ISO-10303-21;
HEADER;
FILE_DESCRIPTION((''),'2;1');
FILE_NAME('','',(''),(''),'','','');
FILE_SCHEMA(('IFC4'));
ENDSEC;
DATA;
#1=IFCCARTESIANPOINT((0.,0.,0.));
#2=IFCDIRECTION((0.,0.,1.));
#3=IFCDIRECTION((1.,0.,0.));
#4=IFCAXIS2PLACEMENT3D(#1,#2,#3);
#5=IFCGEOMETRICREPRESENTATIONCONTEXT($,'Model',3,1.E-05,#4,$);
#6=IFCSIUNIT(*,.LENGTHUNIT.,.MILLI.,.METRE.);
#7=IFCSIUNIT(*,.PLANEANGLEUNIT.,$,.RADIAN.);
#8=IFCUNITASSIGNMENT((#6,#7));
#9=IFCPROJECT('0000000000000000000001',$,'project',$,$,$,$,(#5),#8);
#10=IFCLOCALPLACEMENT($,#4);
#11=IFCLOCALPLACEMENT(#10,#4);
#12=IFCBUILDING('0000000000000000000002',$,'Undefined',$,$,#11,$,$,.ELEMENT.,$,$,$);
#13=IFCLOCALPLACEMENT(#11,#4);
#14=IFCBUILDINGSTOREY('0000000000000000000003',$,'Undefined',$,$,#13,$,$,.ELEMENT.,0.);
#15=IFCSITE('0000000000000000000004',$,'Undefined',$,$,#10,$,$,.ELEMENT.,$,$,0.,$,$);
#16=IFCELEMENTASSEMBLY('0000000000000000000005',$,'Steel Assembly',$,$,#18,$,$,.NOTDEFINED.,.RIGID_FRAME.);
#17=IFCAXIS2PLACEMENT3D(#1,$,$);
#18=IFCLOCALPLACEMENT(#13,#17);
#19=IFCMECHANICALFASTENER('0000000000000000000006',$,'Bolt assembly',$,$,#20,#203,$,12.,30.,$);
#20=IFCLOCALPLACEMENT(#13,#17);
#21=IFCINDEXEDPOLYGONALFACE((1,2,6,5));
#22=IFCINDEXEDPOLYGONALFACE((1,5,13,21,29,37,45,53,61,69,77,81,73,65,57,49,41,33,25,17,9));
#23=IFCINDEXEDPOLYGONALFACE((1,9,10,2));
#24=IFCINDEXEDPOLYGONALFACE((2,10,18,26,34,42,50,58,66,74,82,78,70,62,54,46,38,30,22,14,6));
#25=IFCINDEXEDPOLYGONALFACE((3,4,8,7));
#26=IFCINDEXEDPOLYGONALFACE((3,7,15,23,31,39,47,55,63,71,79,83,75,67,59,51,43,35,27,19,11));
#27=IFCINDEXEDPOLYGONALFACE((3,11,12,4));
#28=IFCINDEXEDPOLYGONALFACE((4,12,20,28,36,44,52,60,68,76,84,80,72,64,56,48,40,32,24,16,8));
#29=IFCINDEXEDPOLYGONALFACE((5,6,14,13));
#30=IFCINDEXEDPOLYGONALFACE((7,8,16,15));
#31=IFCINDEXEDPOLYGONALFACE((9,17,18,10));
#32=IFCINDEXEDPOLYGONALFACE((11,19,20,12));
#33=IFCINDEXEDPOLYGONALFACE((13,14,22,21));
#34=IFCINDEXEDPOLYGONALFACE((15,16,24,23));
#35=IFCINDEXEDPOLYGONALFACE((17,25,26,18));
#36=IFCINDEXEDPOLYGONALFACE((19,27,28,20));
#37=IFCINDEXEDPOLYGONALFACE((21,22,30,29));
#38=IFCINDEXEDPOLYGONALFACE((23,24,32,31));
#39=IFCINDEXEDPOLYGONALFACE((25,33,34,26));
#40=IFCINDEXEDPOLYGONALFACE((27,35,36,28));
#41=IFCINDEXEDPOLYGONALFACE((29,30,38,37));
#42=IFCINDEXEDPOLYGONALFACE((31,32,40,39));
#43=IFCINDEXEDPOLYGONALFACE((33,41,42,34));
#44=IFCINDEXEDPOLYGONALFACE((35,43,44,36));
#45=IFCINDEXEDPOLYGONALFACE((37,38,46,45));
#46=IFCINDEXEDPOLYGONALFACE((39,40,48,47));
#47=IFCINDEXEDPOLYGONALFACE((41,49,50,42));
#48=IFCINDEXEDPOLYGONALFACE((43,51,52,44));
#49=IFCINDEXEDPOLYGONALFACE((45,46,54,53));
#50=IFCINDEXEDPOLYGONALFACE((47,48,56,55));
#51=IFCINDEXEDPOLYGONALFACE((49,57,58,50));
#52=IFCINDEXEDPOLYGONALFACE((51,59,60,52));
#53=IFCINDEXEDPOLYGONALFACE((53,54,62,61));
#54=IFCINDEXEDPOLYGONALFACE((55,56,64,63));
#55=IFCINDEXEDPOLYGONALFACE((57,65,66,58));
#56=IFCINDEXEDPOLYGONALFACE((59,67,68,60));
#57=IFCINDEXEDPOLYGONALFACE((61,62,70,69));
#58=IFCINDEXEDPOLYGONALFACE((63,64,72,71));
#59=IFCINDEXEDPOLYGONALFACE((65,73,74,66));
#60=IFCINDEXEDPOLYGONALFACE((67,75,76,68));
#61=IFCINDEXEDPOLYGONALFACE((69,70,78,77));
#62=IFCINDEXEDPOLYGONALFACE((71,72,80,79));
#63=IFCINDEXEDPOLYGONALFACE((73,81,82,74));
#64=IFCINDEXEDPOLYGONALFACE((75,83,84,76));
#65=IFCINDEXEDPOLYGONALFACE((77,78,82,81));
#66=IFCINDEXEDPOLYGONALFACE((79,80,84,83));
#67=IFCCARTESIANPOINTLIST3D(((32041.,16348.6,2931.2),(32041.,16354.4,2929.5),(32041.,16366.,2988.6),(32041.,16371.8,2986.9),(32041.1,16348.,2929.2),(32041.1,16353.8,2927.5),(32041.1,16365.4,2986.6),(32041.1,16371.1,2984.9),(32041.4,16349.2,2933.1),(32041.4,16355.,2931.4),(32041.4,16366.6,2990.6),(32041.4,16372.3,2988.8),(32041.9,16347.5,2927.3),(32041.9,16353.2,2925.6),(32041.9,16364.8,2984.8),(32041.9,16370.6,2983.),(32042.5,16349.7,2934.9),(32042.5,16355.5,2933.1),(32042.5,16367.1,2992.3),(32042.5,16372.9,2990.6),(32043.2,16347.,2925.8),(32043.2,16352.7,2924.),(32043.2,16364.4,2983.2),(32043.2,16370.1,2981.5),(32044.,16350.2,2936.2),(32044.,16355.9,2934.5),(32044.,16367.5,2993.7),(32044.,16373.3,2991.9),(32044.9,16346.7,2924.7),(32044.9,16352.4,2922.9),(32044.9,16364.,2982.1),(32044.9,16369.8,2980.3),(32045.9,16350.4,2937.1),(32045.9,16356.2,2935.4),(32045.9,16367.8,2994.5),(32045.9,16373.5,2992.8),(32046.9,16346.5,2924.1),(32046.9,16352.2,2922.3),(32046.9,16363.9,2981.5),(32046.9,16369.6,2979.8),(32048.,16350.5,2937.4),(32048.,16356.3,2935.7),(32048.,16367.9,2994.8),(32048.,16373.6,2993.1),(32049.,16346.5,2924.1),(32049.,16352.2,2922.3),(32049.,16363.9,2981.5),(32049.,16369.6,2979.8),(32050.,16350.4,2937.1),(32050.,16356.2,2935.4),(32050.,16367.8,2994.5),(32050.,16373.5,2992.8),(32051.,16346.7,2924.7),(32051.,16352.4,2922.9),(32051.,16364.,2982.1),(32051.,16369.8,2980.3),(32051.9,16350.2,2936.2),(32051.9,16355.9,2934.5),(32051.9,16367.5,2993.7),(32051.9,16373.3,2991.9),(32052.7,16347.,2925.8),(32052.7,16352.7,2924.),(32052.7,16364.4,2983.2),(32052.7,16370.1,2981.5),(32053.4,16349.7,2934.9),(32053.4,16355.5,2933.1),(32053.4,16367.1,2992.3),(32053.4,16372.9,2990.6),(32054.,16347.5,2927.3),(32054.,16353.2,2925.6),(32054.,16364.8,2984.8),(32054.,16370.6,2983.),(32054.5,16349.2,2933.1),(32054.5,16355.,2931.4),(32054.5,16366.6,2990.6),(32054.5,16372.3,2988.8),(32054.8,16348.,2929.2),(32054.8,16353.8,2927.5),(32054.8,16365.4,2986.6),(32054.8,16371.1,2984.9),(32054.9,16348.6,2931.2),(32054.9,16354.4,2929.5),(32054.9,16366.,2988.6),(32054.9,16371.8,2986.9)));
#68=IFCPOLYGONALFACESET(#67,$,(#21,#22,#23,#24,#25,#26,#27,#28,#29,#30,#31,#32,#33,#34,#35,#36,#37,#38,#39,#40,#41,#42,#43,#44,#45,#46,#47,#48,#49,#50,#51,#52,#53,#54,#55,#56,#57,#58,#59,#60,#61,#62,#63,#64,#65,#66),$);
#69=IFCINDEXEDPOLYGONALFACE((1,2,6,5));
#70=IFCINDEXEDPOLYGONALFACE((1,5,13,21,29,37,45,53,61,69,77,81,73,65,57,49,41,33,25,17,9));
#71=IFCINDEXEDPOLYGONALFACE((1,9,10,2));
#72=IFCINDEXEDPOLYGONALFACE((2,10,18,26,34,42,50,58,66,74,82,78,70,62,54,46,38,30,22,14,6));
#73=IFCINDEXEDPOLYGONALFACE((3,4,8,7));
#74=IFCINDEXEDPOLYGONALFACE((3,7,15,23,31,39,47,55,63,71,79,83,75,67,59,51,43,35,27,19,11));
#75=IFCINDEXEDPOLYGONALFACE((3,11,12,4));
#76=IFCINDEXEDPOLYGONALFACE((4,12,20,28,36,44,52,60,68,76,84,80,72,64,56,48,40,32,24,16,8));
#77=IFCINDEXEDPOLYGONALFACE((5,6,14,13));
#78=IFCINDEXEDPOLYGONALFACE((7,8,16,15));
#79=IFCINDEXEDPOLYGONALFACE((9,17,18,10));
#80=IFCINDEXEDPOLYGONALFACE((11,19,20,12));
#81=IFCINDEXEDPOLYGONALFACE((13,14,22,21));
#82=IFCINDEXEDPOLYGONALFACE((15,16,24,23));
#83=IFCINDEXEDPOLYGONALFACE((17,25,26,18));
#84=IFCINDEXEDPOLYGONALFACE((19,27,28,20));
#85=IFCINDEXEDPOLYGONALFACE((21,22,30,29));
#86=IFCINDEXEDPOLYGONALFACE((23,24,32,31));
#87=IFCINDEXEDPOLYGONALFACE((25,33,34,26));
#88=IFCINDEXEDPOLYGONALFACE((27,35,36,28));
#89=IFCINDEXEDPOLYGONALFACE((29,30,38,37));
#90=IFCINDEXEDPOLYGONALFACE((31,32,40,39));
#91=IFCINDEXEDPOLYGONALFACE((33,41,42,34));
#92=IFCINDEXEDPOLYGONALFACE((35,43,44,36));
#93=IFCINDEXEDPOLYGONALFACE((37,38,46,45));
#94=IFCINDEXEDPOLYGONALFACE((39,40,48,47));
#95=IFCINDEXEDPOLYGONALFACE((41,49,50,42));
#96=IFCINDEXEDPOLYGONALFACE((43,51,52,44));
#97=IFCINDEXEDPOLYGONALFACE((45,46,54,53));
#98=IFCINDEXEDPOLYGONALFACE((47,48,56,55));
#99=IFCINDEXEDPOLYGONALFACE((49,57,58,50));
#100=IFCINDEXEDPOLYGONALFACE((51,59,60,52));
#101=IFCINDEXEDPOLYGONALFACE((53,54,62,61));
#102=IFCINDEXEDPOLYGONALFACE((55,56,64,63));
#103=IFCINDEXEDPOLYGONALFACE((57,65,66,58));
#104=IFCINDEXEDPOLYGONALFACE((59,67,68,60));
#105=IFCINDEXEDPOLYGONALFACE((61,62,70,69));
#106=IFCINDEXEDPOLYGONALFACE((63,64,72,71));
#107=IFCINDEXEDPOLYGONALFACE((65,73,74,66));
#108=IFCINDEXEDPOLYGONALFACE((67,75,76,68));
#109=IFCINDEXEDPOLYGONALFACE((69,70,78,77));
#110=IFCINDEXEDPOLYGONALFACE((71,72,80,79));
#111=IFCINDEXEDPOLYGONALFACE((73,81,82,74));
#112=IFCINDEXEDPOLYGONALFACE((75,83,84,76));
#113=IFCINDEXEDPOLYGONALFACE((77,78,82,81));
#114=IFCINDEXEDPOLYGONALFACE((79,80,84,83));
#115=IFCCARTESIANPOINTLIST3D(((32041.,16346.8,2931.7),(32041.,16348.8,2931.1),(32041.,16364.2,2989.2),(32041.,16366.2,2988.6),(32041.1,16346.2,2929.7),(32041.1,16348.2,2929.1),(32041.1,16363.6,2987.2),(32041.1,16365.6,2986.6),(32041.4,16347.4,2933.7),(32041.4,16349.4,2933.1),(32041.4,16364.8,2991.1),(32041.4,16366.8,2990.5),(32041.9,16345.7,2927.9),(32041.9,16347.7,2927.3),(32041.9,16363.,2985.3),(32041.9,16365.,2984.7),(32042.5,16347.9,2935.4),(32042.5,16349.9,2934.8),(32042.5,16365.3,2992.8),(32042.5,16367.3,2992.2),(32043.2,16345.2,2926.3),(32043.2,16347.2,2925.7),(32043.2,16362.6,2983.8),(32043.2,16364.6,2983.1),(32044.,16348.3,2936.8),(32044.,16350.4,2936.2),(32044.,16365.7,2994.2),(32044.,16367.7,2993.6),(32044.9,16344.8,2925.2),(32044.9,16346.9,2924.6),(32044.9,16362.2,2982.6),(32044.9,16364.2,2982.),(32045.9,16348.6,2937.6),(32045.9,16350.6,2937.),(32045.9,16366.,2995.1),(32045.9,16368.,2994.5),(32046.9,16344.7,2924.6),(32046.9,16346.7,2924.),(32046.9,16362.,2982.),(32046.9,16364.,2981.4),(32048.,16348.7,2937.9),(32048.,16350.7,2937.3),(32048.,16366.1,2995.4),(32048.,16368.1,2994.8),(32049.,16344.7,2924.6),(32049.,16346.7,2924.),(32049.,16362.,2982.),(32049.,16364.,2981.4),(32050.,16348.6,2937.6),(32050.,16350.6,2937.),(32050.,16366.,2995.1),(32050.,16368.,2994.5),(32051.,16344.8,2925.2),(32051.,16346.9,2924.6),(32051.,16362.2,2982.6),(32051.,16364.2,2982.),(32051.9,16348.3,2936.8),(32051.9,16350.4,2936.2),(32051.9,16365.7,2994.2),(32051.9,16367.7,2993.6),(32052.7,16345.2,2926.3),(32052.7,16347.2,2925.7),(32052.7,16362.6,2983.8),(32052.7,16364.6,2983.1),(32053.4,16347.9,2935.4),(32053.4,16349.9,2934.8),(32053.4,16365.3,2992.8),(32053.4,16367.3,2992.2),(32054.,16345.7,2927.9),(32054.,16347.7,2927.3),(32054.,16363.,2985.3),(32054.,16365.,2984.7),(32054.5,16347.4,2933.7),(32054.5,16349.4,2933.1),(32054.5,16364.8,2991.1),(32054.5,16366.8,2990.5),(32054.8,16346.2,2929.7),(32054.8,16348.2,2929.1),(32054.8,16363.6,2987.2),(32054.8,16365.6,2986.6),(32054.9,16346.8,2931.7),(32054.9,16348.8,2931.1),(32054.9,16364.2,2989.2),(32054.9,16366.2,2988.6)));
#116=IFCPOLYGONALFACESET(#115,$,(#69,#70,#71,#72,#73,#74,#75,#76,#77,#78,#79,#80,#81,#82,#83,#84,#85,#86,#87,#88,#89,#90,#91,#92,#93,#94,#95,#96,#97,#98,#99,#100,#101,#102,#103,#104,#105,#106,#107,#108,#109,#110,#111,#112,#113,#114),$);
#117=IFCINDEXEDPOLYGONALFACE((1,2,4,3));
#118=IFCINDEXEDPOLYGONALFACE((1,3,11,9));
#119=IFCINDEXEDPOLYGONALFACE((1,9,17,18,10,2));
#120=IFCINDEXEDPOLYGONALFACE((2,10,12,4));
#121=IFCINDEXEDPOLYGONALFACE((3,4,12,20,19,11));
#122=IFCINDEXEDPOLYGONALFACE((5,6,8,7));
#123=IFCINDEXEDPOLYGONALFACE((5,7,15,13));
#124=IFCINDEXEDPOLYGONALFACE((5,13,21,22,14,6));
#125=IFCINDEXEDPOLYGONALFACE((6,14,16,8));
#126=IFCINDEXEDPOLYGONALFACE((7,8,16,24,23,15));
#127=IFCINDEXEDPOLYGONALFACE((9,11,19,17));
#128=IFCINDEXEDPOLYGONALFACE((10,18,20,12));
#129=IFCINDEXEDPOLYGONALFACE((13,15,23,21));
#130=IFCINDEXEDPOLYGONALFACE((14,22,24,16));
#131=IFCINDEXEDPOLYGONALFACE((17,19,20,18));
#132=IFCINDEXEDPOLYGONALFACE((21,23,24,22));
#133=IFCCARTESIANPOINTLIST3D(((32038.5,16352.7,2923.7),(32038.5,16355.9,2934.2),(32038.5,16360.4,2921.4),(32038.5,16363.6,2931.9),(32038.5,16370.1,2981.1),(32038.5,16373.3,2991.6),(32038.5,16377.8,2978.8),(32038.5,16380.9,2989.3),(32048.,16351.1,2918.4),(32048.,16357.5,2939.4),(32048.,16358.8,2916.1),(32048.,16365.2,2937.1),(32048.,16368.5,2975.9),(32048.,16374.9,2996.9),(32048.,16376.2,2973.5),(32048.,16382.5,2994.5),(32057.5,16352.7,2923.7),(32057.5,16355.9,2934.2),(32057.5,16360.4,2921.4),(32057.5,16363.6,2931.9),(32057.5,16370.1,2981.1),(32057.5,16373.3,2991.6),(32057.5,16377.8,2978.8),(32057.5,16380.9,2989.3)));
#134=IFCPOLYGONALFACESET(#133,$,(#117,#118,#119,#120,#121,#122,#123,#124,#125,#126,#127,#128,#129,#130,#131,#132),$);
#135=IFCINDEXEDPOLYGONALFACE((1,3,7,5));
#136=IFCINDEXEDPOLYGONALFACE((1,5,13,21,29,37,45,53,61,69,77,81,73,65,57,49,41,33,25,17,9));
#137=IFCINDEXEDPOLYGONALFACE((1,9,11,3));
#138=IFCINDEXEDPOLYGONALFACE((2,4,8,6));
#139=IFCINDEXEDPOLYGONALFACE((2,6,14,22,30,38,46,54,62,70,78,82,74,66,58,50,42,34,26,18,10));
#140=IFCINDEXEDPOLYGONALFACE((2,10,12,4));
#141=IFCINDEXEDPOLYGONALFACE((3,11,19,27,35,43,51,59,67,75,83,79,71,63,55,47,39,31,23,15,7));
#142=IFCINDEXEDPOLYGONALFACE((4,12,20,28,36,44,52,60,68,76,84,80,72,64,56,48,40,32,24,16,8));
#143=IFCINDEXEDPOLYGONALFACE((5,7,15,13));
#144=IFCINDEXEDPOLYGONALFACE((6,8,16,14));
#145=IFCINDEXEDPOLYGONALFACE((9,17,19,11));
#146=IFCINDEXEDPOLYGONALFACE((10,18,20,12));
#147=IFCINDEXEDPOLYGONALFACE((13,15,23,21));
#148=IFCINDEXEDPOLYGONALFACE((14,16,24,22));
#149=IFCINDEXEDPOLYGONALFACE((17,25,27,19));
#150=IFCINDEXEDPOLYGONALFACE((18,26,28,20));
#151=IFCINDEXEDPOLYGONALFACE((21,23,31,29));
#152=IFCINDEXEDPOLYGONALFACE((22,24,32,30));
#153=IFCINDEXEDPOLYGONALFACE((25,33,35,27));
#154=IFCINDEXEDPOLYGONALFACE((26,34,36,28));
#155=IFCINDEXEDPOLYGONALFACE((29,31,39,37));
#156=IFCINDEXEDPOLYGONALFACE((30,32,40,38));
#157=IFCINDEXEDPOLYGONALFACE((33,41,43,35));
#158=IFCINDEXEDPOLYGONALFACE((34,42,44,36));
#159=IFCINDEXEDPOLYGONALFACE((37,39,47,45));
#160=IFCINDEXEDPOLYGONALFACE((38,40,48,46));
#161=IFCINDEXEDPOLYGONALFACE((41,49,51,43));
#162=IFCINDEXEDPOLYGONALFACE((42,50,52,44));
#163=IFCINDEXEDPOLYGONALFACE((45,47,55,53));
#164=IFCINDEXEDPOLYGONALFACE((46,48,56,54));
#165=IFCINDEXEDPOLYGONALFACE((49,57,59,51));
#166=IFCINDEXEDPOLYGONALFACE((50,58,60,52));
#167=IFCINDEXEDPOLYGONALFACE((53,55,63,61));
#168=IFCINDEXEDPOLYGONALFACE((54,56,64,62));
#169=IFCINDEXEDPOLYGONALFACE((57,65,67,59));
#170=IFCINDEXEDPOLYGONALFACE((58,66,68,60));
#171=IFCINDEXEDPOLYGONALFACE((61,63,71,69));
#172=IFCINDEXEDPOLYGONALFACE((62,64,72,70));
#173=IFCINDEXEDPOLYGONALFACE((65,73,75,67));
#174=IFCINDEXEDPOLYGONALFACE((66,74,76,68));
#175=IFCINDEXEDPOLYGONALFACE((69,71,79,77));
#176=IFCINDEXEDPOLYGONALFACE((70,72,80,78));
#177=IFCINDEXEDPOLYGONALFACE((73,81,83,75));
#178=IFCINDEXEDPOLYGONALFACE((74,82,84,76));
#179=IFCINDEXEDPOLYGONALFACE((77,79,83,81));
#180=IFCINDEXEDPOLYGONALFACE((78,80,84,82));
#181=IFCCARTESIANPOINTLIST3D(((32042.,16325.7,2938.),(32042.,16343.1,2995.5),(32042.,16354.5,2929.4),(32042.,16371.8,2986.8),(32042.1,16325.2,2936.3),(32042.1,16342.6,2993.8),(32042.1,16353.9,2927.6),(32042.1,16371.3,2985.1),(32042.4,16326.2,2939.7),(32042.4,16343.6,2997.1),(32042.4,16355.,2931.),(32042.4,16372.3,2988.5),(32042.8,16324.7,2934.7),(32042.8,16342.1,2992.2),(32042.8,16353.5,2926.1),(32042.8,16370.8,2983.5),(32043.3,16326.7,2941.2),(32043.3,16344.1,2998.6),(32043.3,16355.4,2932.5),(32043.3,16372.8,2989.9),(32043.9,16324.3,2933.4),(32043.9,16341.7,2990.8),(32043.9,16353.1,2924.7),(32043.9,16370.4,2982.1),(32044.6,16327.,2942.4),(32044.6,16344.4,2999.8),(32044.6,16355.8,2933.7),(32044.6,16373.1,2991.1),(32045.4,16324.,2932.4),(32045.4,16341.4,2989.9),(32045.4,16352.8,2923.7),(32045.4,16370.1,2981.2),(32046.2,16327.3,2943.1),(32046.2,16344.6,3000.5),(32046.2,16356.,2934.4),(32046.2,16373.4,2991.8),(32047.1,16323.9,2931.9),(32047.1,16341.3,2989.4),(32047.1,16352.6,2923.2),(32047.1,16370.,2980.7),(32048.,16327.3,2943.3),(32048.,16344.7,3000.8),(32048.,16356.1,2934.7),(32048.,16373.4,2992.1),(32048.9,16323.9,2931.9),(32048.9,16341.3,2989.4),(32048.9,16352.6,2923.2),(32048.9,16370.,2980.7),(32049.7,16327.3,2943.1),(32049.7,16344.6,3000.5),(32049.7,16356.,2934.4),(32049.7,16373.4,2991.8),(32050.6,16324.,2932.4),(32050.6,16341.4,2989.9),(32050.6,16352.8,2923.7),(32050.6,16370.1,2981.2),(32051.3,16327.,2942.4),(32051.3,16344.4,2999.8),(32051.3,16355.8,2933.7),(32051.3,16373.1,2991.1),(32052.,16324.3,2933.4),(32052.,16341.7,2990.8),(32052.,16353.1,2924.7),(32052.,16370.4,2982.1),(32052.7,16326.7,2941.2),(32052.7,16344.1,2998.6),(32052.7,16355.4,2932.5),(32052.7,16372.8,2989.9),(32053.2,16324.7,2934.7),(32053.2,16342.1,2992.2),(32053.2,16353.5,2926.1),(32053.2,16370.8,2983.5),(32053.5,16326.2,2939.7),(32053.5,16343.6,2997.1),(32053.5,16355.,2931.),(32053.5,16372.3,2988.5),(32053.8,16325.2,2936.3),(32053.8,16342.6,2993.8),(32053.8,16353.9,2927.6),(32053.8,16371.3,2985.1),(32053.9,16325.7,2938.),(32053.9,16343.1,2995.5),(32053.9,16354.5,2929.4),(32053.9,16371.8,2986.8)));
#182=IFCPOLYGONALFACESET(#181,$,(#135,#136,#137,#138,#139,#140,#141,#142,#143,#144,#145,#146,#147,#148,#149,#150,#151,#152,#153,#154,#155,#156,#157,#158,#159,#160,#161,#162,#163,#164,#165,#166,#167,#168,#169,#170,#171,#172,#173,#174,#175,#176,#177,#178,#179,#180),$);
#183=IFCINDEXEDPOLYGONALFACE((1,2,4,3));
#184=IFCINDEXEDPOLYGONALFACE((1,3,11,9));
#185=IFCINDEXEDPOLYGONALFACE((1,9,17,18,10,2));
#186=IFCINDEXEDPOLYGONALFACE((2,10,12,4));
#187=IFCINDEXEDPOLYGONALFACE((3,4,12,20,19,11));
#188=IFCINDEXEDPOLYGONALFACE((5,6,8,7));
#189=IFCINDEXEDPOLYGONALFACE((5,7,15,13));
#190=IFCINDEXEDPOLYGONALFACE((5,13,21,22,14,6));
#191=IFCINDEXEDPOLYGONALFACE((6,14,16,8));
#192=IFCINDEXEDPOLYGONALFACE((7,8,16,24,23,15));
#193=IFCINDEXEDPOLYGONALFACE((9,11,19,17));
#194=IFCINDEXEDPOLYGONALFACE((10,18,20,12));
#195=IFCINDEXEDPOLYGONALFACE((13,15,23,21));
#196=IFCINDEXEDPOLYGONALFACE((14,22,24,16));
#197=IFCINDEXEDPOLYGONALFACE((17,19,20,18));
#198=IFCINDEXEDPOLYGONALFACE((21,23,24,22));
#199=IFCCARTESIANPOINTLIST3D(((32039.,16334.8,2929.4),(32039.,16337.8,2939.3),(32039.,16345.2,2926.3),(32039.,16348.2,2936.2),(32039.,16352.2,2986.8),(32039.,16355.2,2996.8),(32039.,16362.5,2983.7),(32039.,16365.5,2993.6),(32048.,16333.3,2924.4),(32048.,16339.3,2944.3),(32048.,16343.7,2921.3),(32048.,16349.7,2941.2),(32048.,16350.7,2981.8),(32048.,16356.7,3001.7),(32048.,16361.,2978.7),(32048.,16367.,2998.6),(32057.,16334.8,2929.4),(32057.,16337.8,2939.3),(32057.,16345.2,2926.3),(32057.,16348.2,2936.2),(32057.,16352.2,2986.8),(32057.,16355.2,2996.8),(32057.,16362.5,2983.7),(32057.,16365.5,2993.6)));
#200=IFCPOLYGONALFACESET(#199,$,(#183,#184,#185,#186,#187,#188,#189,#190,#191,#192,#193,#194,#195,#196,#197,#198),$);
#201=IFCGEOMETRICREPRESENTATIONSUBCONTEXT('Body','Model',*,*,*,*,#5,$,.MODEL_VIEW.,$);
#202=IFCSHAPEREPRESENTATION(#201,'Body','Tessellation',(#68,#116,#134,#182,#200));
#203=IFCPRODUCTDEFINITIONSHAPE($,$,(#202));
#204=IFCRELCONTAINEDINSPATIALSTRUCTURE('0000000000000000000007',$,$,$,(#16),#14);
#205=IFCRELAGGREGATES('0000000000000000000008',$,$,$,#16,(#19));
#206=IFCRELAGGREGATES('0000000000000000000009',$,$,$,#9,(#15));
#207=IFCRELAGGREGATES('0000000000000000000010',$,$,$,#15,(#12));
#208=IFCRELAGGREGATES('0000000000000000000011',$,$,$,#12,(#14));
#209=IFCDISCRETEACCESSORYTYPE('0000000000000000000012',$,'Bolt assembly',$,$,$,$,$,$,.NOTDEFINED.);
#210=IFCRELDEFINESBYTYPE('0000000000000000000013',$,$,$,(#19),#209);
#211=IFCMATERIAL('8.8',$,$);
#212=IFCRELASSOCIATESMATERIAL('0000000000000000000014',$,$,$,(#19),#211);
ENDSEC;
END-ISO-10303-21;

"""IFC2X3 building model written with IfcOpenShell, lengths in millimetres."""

from ifc_helpers import new_model, si_unit, frame, origin_with_axes, origin_2d_with_axis, place, context, subcontext, project, spatial, polyline, circle, outline, extrude, source, transform, mapped, material, type_object, element, aggregate, save


model = new_model("IFC2X3")

# Units and contexts
model_context = context("Model", 3, precision=1e-05, world=origin_with_axes())
body_context = subcontext(model_context, "Body", "Model", "MODEL_VIEW")
ifc_project = project(units=[si_unit("LENGTHUNIT", "METRE", prefix="MILLI"), si_unit("PLANEANGLEUNIT", "RADIAN")], contexts=[model_context])

# Site, building, storey
site_placement = place(None, origin_with_axes())
site = spatial("IfcSite", under=ifc_project, at=site_placement, Name="Undefined", CompositionType="ELEMENT", RefElevation=0.0)
building_placement = place(site_placement, origin_with_axes())
building = spatial("IfcBuilding", under=site, at=building_placement, Name="Undefined", CompositionType="ELEMENT")
storey_placement = place(building_placement, origin_with_axes())
storey = spatial("IfcBuildingStorey", under=building, at=storey_placement, Name="Undefined", CompositionType="ELEMENT", Elevation=0.0)

# Element assembly
assembly_1_placement = place(storey_placement, origin_with_axes())
assembly_1 = element("IfcElementAssembly", 1, at=assembly_1_placement, inside=storey, Name="Steel Assembly", AssemblyPlace="NOTDEFINED", PredefinedType="RIGID_FRAME")

# Shared definitions
discrete_accessory_type_1 = type_object("IfcDiscreteAccessoryType", Name="Bolt assembly")

# Shared definitions
ifc_material_1 = material(Name="8.8")
shared_shape_1 = source(origin_with_axes(), body_context, "Body", "SweptSolid", [
    extrude(circle(Radius=7.0, at=origin_2d_with_axis()), frame((0.0, -2.9, 0.0), z_axis=(0.0, 1.0, 0.0), x_axis=(1.0, 0.0, 0.0)), (0.0, 0.0, 1.0), 6.0),
    extrude(circle(Radius=7.0, at=origin_2d_with_axis()), frame((0.0, 2.9, 0.0), z_axis=(0.0, 1.0, 0.0), x_axis=(1.0, 0.0, 0.0)), (0.0, 0.0, 1.0), 2.1),
    extrude(outline(polyline([(11.0, 0.0), (5.5, 9.5), (-5.5, 9.5), (-11.0, 0.0), (-5.5, -9.5), (5.5, -9.5), (11.0, 0.0)])), frame((0.0, -11.0, 0.0), z_axis=(0.0, 1.0, 0.0), x_axis=(1.0, 0.0, 0.0)), (0.0, 0.0, 1.0), 8.0),
    extrude(circle(Radius=6.0, at=origin_2d_with_axis()), frame((0.0, -3.0, 0.0), z_axis=(0.0, 1.0, 0.0), x_axis=(1.0, 0.0, 0.0)), (0.0, 0.0, 1.0), 30.0),
    extrude(outline(polyline([(10.4, 0.0), (5.2, 9.0), (-5.2, 9.0), (-10.4, 0.0), (-5.2, -9.0), (5.2, -9.0), (10.4, 0.0)])), frame((0.0, 5.0, 0.0), z_axis=(0.0, 1.0, 0.0), x_axis=(1.0, 0.0, 0.0)), (0.0, 0.0, 1.0), 10.8),
])

# Mechanical fastener
mechanical_fastener_1_placement = place(assembly_1_placement, frame((32003.0, 16338.4, 2886.7), z_axis=(1.0, 0.0, 0.0), x_axis=(0.0, 0.289497, 0.957179)))
mechanical_fastener_1 = element("IfcMechanicalFastener", 2, at=mechanical_fastener_1_placement, type_object=discrete_accessory_type_1, material=ifc_material_1, Name="Bolt assembly", NominalDiameter=12.0, NominalLength=30.0, context=body_context, shape_type="MappedRepresentation", body=[
    mapped(shared_shape_1, transform((45.0, 0.0, 45.0))),
    mapped(shared_shape_1, transform((105.0, 0.0, 45.0))),
])
aggregate(assembly_1, [mechanical_fastener_1])

save(model, "model.ifc")
